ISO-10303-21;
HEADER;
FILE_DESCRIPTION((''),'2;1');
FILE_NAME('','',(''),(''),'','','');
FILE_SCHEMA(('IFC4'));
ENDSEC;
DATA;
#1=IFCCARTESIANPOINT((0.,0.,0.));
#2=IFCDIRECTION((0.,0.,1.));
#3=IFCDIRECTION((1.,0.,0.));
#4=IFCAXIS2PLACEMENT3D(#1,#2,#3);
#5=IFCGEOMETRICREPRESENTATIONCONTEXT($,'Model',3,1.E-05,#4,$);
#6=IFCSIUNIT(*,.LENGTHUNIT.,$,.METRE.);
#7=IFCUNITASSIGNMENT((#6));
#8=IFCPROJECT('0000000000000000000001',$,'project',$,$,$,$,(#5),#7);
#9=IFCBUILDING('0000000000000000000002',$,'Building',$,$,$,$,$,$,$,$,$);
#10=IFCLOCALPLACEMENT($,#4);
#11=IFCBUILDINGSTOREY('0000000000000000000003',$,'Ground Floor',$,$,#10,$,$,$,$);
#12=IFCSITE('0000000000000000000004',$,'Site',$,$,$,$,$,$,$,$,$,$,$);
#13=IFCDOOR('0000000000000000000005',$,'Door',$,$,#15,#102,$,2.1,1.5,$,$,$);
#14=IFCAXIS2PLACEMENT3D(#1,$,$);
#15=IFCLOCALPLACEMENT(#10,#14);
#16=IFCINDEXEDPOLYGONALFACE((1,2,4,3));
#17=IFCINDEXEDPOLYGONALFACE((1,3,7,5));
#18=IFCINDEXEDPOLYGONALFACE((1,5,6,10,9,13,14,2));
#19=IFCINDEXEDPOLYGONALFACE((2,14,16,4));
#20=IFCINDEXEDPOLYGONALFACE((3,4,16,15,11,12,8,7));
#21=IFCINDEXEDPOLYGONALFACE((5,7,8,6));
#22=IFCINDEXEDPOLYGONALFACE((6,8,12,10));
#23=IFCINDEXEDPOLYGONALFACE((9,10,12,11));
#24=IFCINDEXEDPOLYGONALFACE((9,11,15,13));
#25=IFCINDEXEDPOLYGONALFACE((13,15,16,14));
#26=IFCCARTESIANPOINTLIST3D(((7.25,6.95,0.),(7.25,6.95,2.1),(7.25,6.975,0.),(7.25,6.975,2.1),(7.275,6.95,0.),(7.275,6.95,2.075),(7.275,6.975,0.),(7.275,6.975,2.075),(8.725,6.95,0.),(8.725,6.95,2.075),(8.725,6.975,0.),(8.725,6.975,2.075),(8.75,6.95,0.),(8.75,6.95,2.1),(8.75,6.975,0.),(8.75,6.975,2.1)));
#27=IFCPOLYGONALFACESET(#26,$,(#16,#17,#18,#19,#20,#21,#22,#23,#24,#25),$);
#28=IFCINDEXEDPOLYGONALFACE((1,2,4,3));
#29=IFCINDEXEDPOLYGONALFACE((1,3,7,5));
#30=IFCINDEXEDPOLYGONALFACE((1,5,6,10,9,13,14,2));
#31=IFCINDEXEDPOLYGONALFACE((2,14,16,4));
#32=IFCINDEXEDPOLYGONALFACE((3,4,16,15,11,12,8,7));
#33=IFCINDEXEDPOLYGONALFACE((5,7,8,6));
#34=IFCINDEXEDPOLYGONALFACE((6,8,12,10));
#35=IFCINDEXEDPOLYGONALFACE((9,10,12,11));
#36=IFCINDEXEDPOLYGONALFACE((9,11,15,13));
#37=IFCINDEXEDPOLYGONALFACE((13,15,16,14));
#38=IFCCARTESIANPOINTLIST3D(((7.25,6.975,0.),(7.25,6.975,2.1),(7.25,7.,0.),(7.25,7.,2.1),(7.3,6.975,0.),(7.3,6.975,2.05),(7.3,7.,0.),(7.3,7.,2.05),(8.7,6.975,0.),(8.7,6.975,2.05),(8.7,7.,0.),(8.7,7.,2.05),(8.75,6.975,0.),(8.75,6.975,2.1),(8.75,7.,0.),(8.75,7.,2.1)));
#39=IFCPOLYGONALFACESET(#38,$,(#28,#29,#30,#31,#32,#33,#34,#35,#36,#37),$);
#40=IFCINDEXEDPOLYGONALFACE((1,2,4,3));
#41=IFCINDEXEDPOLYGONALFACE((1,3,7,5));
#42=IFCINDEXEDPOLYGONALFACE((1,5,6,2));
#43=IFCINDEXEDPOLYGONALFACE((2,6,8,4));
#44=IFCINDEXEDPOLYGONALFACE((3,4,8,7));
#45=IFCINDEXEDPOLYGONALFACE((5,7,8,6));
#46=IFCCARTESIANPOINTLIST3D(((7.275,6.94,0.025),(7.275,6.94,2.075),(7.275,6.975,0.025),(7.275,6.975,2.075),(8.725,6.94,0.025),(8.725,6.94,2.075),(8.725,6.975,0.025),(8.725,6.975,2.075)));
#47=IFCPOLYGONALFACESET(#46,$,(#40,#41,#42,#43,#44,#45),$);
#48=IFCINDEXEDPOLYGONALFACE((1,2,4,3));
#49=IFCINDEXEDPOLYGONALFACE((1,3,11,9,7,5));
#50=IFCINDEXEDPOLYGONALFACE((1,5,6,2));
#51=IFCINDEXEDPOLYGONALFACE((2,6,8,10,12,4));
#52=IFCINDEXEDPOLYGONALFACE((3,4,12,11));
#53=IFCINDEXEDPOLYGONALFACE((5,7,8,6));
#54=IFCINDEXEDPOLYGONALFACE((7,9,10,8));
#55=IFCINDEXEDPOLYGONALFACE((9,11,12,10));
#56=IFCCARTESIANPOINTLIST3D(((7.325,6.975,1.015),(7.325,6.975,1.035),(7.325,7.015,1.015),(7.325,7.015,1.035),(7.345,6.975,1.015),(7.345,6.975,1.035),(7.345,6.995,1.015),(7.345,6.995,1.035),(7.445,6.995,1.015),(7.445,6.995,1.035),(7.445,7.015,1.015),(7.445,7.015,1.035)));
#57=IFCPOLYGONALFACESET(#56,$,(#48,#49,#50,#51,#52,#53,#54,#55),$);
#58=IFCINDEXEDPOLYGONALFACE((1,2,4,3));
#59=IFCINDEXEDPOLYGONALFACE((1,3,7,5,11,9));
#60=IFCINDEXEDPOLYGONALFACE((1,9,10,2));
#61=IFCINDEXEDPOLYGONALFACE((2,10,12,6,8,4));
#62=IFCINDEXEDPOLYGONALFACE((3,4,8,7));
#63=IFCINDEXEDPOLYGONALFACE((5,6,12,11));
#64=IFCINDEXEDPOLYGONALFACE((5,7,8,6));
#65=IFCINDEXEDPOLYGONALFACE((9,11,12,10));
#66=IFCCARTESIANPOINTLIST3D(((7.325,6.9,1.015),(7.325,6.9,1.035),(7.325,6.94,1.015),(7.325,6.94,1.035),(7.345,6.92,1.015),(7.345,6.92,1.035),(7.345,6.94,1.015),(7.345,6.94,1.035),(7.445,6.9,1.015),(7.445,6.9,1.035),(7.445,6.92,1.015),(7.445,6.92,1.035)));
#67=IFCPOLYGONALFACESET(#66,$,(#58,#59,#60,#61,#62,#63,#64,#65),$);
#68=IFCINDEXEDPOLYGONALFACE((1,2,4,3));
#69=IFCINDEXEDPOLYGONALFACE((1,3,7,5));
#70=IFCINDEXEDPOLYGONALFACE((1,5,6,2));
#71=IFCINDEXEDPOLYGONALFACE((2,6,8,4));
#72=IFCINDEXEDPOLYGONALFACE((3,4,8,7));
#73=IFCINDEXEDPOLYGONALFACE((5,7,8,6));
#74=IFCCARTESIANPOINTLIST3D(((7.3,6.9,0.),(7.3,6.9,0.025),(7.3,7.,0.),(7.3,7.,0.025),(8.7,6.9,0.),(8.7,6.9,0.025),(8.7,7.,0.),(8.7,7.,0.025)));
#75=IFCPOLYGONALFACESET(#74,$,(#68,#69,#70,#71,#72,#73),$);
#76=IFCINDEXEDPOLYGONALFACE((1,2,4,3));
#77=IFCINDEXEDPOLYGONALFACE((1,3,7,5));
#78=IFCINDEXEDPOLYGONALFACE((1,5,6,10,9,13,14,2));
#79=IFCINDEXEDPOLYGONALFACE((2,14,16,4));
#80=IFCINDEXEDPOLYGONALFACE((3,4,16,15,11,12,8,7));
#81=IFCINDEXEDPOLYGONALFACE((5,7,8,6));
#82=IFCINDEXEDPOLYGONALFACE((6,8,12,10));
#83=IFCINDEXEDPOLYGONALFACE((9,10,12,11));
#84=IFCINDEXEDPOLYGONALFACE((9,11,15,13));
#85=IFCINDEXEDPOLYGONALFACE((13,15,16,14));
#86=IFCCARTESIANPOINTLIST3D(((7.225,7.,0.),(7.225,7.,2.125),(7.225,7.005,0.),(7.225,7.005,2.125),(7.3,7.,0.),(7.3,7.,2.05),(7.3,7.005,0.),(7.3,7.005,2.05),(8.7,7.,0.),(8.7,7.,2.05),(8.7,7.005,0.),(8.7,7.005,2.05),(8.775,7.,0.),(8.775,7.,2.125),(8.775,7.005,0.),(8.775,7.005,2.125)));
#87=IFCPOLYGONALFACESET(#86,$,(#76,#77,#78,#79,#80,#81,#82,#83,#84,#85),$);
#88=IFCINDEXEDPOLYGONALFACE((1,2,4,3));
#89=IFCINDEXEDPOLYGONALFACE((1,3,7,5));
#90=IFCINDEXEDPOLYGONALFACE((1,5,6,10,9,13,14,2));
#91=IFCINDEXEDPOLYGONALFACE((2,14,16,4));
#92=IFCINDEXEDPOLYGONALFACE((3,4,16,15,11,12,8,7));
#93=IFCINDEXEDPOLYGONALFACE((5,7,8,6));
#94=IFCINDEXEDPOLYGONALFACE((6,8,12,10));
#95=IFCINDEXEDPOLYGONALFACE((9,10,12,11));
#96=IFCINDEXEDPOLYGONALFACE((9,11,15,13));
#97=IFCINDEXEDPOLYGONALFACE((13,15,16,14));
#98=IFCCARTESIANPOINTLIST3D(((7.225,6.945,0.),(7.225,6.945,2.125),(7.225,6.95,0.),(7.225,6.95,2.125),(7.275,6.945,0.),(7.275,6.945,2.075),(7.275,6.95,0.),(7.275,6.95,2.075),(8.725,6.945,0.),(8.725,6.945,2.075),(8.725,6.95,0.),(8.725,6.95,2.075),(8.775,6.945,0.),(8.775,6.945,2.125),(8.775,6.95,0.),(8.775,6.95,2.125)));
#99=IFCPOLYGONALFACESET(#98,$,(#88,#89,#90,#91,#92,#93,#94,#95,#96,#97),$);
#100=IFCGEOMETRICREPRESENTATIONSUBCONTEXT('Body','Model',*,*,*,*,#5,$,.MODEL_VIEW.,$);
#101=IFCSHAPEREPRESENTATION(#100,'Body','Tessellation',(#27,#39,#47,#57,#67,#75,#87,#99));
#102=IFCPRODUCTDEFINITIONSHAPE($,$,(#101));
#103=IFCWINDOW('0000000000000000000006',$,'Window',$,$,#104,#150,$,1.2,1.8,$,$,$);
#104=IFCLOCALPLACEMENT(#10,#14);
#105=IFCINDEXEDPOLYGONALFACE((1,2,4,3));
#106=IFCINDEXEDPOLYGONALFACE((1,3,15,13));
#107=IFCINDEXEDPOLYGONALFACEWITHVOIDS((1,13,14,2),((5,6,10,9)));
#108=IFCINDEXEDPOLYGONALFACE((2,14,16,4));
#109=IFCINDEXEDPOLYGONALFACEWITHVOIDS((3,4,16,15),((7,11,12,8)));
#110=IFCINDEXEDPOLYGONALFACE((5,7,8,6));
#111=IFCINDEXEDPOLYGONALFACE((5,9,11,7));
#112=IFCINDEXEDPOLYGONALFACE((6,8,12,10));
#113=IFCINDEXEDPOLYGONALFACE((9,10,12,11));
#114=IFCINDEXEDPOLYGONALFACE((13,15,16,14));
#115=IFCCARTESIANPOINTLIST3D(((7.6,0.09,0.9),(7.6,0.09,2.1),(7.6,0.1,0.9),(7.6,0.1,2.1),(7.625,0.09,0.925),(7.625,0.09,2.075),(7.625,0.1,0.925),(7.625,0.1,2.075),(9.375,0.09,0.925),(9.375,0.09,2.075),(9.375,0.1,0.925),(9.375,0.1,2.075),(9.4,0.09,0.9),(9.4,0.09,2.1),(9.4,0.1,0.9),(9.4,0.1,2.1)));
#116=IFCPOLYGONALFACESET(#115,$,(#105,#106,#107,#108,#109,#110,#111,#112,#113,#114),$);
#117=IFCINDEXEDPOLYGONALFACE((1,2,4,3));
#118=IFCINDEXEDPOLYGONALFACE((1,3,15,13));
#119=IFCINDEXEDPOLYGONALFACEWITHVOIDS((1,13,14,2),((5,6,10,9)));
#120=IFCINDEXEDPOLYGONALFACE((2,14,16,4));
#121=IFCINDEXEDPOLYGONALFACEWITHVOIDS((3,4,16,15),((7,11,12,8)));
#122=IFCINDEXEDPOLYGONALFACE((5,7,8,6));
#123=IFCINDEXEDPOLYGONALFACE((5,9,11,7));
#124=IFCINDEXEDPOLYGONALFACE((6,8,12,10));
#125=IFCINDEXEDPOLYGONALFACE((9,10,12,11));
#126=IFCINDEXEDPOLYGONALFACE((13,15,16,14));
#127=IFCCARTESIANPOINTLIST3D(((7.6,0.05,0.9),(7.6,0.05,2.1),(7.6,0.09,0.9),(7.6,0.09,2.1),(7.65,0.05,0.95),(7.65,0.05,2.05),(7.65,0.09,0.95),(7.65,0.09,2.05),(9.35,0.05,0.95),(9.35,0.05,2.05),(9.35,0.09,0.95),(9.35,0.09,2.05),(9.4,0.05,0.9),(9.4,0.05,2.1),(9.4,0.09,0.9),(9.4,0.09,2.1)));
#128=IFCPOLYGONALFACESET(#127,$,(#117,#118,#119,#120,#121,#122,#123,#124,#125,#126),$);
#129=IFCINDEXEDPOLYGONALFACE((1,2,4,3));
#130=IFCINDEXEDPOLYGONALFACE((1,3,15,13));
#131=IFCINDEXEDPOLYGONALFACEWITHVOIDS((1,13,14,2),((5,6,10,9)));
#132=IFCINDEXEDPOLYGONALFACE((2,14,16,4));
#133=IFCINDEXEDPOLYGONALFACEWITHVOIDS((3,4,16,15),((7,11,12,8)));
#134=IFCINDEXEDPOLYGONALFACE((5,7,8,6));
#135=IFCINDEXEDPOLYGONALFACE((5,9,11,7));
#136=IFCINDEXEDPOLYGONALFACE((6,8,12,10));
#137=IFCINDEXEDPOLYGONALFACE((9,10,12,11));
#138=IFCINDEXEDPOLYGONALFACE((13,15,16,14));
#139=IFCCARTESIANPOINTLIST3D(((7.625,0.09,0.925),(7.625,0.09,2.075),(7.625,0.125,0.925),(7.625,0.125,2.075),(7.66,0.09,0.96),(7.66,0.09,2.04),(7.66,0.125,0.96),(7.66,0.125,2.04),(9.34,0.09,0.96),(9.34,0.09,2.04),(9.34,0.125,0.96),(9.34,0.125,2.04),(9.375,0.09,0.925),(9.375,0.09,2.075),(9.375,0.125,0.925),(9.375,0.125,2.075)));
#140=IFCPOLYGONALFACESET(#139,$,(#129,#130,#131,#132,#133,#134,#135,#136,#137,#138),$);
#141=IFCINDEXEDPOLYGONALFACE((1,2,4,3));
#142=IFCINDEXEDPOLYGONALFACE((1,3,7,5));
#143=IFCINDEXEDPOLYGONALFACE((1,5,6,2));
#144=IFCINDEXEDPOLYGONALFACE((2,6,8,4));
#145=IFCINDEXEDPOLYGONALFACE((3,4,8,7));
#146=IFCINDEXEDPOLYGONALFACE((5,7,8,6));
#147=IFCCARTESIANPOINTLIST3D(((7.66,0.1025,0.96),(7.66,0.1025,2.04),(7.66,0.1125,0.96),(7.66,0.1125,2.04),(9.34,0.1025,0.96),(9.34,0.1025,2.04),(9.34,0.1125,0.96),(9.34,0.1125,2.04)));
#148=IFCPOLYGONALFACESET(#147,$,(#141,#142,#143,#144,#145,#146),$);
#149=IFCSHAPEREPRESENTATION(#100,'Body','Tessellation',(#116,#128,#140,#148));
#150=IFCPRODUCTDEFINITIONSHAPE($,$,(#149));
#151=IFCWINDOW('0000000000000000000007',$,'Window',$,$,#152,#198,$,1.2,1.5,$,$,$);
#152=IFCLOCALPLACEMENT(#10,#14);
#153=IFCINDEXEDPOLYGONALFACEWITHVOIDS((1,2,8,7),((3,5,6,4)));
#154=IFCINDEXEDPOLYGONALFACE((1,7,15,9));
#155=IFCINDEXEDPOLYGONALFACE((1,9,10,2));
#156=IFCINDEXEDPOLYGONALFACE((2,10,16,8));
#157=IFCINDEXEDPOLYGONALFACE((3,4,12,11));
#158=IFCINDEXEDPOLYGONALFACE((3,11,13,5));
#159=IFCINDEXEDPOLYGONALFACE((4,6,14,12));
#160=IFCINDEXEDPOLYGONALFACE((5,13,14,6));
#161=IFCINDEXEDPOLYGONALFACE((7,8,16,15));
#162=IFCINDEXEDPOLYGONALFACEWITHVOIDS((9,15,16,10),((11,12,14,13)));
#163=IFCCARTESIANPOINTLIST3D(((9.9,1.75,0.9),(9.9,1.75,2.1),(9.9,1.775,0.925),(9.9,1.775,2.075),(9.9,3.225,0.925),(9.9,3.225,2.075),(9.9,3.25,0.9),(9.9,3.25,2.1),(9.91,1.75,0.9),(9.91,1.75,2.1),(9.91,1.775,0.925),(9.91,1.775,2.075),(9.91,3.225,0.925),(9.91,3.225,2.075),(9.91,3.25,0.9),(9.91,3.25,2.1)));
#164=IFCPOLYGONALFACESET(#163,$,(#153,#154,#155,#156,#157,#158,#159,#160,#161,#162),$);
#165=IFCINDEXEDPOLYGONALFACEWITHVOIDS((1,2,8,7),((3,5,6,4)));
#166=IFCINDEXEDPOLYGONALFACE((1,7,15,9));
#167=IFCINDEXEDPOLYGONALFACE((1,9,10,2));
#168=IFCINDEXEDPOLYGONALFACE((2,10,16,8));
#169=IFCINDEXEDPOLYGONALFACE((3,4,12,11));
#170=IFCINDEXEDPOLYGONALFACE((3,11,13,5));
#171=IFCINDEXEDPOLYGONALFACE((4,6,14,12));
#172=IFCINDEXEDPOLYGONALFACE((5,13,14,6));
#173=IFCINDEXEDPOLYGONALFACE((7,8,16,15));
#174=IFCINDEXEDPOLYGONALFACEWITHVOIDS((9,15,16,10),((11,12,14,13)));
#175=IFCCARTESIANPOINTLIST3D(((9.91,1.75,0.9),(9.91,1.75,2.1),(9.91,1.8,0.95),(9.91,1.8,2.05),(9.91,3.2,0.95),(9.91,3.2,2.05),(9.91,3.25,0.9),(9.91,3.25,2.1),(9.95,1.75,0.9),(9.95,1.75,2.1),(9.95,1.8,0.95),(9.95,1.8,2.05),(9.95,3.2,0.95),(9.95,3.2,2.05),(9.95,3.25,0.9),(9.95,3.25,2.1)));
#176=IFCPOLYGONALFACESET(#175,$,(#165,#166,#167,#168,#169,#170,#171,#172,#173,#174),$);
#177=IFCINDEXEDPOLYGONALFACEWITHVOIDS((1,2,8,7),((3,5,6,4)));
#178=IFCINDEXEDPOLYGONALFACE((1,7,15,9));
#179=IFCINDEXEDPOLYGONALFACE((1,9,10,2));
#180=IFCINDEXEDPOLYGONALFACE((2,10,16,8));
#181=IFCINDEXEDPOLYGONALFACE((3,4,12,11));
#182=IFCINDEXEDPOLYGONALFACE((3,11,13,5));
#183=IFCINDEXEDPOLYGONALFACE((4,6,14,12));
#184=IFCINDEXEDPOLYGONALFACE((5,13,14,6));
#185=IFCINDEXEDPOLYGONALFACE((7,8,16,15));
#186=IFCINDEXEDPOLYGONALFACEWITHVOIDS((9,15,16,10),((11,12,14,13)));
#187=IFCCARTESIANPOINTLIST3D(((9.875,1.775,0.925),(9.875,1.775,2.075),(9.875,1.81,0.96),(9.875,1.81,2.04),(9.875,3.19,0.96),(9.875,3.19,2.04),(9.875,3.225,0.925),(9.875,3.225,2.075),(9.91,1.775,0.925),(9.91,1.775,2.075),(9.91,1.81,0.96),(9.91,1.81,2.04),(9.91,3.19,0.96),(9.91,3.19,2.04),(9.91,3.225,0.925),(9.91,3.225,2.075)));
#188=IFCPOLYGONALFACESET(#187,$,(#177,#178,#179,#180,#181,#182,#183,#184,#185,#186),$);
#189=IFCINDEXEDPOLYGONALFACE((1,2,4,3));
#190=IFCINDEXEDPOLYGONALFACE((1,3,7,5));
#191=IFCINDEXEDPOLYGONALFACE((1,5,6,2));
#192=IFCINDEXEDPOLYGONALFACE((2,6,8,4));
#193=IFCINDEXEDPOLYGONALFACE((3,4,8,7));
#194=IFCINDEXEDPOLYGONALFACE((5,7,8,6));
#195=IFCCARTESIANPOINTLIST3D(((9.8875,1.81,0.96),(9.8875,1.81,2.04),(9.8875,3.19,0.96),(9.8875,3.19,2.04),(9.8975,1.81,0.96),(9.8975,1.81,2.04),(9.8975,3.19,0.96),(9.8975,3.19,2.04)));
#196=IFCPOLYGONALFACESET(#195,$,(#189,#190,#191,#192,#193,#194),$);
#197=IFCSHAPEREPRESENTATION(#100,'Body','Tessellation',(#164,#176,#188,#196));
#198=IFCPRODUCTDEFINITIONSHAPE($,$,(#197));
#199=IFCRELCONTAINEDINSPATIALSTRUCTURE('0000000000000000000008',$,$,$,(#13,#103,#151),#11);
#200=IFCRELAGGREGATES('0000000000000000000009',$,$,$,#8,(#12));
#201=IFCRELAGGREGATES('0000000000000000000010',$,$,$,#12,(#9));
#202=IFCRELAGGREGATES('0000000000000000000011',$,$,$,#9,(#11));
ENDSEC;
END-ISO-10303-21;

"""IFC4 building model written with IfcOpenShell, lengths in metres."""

from ifc_helpers import new_model, si_unit, frame, origin_with_axes, place, context, subcontext, project, spatial, line, indexed_curve, outline, extrude, element, save


model = new_model("IFC4")

# Units and contexts
model_context = context("Model", 3, precision=1e-05, world=origin_with_axes())
body_context = subcontext(model_context, "Body", "Model", "MODEL_VIEW")
ifc_project = project(units=[si_unit("LENGTHUNIT", "METRE")], contexts=[model_context])

# Site, building, storey
site = spatial("IfcSite", under=ifc_project, Name="Site")
building = spatial("IfcBuilding", under=site, Name="Building")
storey_placement = place(None, origin_with_axes())
storey = spatial("IfcBuildingStorey", under=building, at=storey_placement, Name="Ground Floor")

# Door
door_1_placement = place(storey_placement, frame((8.75, 7.0, 0.0), z_axis=(0.0, 0.0, 1.0), x_axis=(-1.0, 0.0, 0.0)))
element("IfcDoor", 1, at=door_1_placement, inside=storey, Name="Door", OverallHeight=2.1, OverallWidth=1.5, context=body_context, shape_type="SweptSolid", body=[
    extrude(outline(indexed_curve([(0.0, 0.0), (0.0, 2.1), (1.5, 2.1), (1.5, 0.0), (1.475, 0.0), (1.475, 2.075), (0.025, 2.075), (0.025, 0.0)], segments=[line(1, 2, 3, 4, 5, 6, 7, 8, 1)])), frame((0.0, 0.025, 0.0), z_axis=(0.0, -1.0, 0.0), x_axis=(1.0, 0.0, 0.0)), (0.0, 0.0, -1.0), 0.025),
    extrude(outline(indexed_curve([(0.0, 0.0), (0.0, 2.1), (1.5, 2.1), (1.5, 0.0), (1.45, 0.0), (1.45, 2.05), (0.05, 2.05), (0.05, 0.0)], segments=[line(1, 2, 3, 4, 5, 6, 7, 8, 1)])), frame((0.0, 0.0, 0.0), z_axis=(0.0, -1.0, 0.0), x_axis=(1.0, 0.0, 0.0)), (0.0, 0.0, -1.0), 0.025),
    extrude(outline(indexed_curve([(0.0, 0.0), (1.45, 0.0), (1.45, 0.035), (0.0, 0.035)], segments=[line(1, 2, 3, 4, 1)])), frame((0.025, 0.025, 0.025), z_axis=(0.0, 0.0, 1.0), x_axis=(1.0, 0.0, 0.0)), (0.0, 0.0, 1.0), 2.05),
    extrude(outline(indexed_curve([(0.0, 0.0), (0.0, -0.04), (-0.12, -0.04), (-0.12, -0.02), (-0.02, -0.02), (-0.02, 0.0)], segments=[line(1, 2, 3, 4, 5, 6, 1)])), frame((1.425, 0.025, 1.015), z_axis=(0.0, 0.0, 1.0), x_axis=(1.0, 0.0, 0.0)), (0.0, 0.0, 1.0), 0.02),
    extrude(outline(indexed_curve([(0.0, 0.0), (0.0, 0.04), (-0.12, 0.04), (-0.12, 0.02), (-0.02, 0.02), (-0.02, 0.0)], segments=[line(1, 2, 3, 4, 5, 6, 1)])), frame((1.425, 0.06, 1.015), z_axis=(0.0, 0.0, 1.0), x_axis=(1.0, 0.0, 0.0)), (0.0, 0.0, 1.0), 0.02),
    extrude(outline(indexed_curve([(0.0, 0.0), (1.4, 0.0), (1.4, 0.1), (0.0, 0.1)], segments=[line(1, 2, 3, 4, 1)])), frame((0.05, 0.0, 0.0), z_axis=(0.0, 0.0, 1.0), x_axis=(1.0, 0.0, 0.0)), (0.0, 0.0, 1.0), 0.025),
    extrude(outline(indexed_curve([(0.0, 0.0), (0.0, 2.125), (1.55, 2.125), (1.55, 0.0), (1.475, 0.0), (1.475, 2.05), (0.075, 2.05), (0.075, 0.0)], segments=[line(1, 2, 3, 4, 5, 6, 7, 8, 1)])), frame((-0.025, -0.005, 0.0), z_axis=(0.0, -1.0, 0.0), x_axis=(1.0, 0.0, 0.0)), (0.0, 0.0, -1.0), 0.005),
    extrude(outline(indexed_curve([(0.0, 0.0), (0.0, 2.125), (1.55, 2.125), (1.55, 0.0), (1.5, 0.0), (1.5, 2.075), (0.05, 2.075), (0.05, 0.0)], segments=[line(1, 2, 3, 4, 5, 6, 7, 8, 1)])), frame((-0.025, 0.05, 0.0), z_axis=(0.0, -1.0, 0.0), x_axis=(1.0, 0.0, 0.0)), (0.0, 0.0, -1.0), 0.005),
])

# Windows
window_1_placement = place(storey_placement, frame((7.6, 0.0, 0.9), z_axis=(0.0, 0.0, 1.0), x_axis=(1.0, 0.0, 0.0)))
element("IfcWindow", 2, at=window_1_placement, inside=storey, Name="Window", OverallHeight=1.2, OverallWidth=1.8, context=body_context, shape_type="SweptSolid", body=[
    extrude(outline(indexed_curve([(0.0, 0.0), (1.8, 0.0), (1.8, 1.2), (0.0, 1.2)], segments=[line(1, 2, 3, 4, 1)]), holes=[indexed_curve([(0.025, 0.025), (1.775, 0.025), (1.775, 1.175), (0.025, 1.175)], segments=[line(1, 2, 3, 4, 1)])]), frame((0.0, 0.09, 0.0), z_axis=(0.0, -1.0, 0.0), x_axis=(1.0, 0.0, 0.0)), (0.0, 0.0, -1.0), 0.01),
    extrude(outline(indexed_curve([(0.0, 0.0), (1.8, 0.0), (1.8, 1.2), (0.0, 1.2)], segments=[line(1, 2, 3, 4, 1)]), holes=[indexed_curve([(0.05, 0.05), (1.75, 0.05), (1.75, 1.15), (0.05, 1.15)], segments=[line(1, 2, 3, 4, 1)])]), frame((0.0, 0.05, 0.0), z_axis=(0.0, -1.0, 0.0), x_axis=(1.0, 0.0, 0.0)), (0.0, 0.0, -1.0), 0.04),
    extrude(outline(indexed_curve([(0.0, 0.0), (1.75, 0.0), (1.75, 1.15), (0.0, 1.15)], segments=[line(1, 2, 3, 4, 1)]), holes=[indexed_curve([(0.035, 0.035), (1.715, 0.035), (1.715, 1.115), (0.035, 1.115)], segments=[line(1, 2, 3, 4, 1)])]), frame((0.025, 0.09, 0.025), z_axis=(0.0, -1.0, 0.0), x_axis=(1.0, 0.0, 0.0)), (0.0, 0.0, -1.0), 0.035),
    extrude(outline(indexed_curve([(0.035, 0.035), (1.715, 0.035), (1.715, 1.115), (0.035, 1.115)], segments=[line(1, 2, 3, 4, 1)])), frame((0.025, 0.1025, 0.025), z_axis=(0.0, -1.0, 0.0), x_axis=(1.0, 0.0, 0.0)), (0.0, 0.0, -1.0), 0.01),
])
for number, where, z_axis, x_axis, name in (
    (3, (10.0, 1.75, 0.9), (0.0, 0.0, 1.0), (0.0, 1.0, 0.0), "Window"),
):
    element("IfcWindow", number, at=place(storey_placement, frame(where, z_axis=z_axis, x_axis=x_axis)), inside=storey, Name=name, OverallHeight=1.2, OverallWidth=1.5, context=body_context, shape_type="SweptSolid", body=[
        extrude(outline(indexed_curve([(0.0, 0.0), (1.5, 0.0), (1.5, 1.2), (0.0, 1.2)], segments=[line(1, 2, 3, 4, 1)]), holes=[indexed_curve([(0.025, 0.025), (1.475, 0.025), (1.475, 1.175), (0.025, 1.175)], segments=[line(1, 2, 3, 4, 1)])]), frame((0.0, 0.09, 0.0), z_axis=(0.0, -1.0, 0.0), x_axis=(1.0, 0.0, 0.0)), (0.0, 0.0, -1.0), 0.01),
        extrude(outline(indexed_curve([(0.0, 0.0), (1.5, 0.0), (1.5, 1.2), (0.0, 1.2)], segments=[line(1, 2, 3, 4, 1)]), holes=[indexed_curve([(0.05, 0.05), (1.45, 0.05), (1.45, 1.15), (0.05, 1.15)], segments=[line(1, 2, 3, 4, 1)])]), frame((0.0, 0.05, 0.0), z_axis=(0.0, -1.0, 0.0), x_axis=(1.0, 0.0, 0.0)), (0.0, 0.0, -1.0), 0.04),
        extrude(outline(indexed_curve([(0.0, 0.0), (1.45, 0.0), (1.45, 1.15), (0.0, 1.15)], segments=[line(1, 2, 3, 4, 1)]), holes=[indexed_curve([(0.035, 0.035), (1.415, 0.035), (1.415, 1.115), (0.035, 1.115)], segments=[line(1, 2, 3, 4, 1)])]), frame((0.025, 0.09, 0.025), z_axis=(0.0, -1.0, 0.0), x_axis=(1.0, 0.0, 0.0)), (0.0, 0.0, -1.0), 0.035),
        extrude(outline(indexed_curve([(0.035, 0.035), (1.415, 0.035), (1.415, 1.115), (0.035, 1.115)], segments=[line(1, 2, 3, 4, 1)])), frame((0.025, 0.1025, 0.025), z_axis=(0.0, -1.0, 0.0), x_axis=(1.0, 0.0, 0.0)), (0.0, 0.0, -1.0), 0.01),
    ])

save(model, "model.ifc")
